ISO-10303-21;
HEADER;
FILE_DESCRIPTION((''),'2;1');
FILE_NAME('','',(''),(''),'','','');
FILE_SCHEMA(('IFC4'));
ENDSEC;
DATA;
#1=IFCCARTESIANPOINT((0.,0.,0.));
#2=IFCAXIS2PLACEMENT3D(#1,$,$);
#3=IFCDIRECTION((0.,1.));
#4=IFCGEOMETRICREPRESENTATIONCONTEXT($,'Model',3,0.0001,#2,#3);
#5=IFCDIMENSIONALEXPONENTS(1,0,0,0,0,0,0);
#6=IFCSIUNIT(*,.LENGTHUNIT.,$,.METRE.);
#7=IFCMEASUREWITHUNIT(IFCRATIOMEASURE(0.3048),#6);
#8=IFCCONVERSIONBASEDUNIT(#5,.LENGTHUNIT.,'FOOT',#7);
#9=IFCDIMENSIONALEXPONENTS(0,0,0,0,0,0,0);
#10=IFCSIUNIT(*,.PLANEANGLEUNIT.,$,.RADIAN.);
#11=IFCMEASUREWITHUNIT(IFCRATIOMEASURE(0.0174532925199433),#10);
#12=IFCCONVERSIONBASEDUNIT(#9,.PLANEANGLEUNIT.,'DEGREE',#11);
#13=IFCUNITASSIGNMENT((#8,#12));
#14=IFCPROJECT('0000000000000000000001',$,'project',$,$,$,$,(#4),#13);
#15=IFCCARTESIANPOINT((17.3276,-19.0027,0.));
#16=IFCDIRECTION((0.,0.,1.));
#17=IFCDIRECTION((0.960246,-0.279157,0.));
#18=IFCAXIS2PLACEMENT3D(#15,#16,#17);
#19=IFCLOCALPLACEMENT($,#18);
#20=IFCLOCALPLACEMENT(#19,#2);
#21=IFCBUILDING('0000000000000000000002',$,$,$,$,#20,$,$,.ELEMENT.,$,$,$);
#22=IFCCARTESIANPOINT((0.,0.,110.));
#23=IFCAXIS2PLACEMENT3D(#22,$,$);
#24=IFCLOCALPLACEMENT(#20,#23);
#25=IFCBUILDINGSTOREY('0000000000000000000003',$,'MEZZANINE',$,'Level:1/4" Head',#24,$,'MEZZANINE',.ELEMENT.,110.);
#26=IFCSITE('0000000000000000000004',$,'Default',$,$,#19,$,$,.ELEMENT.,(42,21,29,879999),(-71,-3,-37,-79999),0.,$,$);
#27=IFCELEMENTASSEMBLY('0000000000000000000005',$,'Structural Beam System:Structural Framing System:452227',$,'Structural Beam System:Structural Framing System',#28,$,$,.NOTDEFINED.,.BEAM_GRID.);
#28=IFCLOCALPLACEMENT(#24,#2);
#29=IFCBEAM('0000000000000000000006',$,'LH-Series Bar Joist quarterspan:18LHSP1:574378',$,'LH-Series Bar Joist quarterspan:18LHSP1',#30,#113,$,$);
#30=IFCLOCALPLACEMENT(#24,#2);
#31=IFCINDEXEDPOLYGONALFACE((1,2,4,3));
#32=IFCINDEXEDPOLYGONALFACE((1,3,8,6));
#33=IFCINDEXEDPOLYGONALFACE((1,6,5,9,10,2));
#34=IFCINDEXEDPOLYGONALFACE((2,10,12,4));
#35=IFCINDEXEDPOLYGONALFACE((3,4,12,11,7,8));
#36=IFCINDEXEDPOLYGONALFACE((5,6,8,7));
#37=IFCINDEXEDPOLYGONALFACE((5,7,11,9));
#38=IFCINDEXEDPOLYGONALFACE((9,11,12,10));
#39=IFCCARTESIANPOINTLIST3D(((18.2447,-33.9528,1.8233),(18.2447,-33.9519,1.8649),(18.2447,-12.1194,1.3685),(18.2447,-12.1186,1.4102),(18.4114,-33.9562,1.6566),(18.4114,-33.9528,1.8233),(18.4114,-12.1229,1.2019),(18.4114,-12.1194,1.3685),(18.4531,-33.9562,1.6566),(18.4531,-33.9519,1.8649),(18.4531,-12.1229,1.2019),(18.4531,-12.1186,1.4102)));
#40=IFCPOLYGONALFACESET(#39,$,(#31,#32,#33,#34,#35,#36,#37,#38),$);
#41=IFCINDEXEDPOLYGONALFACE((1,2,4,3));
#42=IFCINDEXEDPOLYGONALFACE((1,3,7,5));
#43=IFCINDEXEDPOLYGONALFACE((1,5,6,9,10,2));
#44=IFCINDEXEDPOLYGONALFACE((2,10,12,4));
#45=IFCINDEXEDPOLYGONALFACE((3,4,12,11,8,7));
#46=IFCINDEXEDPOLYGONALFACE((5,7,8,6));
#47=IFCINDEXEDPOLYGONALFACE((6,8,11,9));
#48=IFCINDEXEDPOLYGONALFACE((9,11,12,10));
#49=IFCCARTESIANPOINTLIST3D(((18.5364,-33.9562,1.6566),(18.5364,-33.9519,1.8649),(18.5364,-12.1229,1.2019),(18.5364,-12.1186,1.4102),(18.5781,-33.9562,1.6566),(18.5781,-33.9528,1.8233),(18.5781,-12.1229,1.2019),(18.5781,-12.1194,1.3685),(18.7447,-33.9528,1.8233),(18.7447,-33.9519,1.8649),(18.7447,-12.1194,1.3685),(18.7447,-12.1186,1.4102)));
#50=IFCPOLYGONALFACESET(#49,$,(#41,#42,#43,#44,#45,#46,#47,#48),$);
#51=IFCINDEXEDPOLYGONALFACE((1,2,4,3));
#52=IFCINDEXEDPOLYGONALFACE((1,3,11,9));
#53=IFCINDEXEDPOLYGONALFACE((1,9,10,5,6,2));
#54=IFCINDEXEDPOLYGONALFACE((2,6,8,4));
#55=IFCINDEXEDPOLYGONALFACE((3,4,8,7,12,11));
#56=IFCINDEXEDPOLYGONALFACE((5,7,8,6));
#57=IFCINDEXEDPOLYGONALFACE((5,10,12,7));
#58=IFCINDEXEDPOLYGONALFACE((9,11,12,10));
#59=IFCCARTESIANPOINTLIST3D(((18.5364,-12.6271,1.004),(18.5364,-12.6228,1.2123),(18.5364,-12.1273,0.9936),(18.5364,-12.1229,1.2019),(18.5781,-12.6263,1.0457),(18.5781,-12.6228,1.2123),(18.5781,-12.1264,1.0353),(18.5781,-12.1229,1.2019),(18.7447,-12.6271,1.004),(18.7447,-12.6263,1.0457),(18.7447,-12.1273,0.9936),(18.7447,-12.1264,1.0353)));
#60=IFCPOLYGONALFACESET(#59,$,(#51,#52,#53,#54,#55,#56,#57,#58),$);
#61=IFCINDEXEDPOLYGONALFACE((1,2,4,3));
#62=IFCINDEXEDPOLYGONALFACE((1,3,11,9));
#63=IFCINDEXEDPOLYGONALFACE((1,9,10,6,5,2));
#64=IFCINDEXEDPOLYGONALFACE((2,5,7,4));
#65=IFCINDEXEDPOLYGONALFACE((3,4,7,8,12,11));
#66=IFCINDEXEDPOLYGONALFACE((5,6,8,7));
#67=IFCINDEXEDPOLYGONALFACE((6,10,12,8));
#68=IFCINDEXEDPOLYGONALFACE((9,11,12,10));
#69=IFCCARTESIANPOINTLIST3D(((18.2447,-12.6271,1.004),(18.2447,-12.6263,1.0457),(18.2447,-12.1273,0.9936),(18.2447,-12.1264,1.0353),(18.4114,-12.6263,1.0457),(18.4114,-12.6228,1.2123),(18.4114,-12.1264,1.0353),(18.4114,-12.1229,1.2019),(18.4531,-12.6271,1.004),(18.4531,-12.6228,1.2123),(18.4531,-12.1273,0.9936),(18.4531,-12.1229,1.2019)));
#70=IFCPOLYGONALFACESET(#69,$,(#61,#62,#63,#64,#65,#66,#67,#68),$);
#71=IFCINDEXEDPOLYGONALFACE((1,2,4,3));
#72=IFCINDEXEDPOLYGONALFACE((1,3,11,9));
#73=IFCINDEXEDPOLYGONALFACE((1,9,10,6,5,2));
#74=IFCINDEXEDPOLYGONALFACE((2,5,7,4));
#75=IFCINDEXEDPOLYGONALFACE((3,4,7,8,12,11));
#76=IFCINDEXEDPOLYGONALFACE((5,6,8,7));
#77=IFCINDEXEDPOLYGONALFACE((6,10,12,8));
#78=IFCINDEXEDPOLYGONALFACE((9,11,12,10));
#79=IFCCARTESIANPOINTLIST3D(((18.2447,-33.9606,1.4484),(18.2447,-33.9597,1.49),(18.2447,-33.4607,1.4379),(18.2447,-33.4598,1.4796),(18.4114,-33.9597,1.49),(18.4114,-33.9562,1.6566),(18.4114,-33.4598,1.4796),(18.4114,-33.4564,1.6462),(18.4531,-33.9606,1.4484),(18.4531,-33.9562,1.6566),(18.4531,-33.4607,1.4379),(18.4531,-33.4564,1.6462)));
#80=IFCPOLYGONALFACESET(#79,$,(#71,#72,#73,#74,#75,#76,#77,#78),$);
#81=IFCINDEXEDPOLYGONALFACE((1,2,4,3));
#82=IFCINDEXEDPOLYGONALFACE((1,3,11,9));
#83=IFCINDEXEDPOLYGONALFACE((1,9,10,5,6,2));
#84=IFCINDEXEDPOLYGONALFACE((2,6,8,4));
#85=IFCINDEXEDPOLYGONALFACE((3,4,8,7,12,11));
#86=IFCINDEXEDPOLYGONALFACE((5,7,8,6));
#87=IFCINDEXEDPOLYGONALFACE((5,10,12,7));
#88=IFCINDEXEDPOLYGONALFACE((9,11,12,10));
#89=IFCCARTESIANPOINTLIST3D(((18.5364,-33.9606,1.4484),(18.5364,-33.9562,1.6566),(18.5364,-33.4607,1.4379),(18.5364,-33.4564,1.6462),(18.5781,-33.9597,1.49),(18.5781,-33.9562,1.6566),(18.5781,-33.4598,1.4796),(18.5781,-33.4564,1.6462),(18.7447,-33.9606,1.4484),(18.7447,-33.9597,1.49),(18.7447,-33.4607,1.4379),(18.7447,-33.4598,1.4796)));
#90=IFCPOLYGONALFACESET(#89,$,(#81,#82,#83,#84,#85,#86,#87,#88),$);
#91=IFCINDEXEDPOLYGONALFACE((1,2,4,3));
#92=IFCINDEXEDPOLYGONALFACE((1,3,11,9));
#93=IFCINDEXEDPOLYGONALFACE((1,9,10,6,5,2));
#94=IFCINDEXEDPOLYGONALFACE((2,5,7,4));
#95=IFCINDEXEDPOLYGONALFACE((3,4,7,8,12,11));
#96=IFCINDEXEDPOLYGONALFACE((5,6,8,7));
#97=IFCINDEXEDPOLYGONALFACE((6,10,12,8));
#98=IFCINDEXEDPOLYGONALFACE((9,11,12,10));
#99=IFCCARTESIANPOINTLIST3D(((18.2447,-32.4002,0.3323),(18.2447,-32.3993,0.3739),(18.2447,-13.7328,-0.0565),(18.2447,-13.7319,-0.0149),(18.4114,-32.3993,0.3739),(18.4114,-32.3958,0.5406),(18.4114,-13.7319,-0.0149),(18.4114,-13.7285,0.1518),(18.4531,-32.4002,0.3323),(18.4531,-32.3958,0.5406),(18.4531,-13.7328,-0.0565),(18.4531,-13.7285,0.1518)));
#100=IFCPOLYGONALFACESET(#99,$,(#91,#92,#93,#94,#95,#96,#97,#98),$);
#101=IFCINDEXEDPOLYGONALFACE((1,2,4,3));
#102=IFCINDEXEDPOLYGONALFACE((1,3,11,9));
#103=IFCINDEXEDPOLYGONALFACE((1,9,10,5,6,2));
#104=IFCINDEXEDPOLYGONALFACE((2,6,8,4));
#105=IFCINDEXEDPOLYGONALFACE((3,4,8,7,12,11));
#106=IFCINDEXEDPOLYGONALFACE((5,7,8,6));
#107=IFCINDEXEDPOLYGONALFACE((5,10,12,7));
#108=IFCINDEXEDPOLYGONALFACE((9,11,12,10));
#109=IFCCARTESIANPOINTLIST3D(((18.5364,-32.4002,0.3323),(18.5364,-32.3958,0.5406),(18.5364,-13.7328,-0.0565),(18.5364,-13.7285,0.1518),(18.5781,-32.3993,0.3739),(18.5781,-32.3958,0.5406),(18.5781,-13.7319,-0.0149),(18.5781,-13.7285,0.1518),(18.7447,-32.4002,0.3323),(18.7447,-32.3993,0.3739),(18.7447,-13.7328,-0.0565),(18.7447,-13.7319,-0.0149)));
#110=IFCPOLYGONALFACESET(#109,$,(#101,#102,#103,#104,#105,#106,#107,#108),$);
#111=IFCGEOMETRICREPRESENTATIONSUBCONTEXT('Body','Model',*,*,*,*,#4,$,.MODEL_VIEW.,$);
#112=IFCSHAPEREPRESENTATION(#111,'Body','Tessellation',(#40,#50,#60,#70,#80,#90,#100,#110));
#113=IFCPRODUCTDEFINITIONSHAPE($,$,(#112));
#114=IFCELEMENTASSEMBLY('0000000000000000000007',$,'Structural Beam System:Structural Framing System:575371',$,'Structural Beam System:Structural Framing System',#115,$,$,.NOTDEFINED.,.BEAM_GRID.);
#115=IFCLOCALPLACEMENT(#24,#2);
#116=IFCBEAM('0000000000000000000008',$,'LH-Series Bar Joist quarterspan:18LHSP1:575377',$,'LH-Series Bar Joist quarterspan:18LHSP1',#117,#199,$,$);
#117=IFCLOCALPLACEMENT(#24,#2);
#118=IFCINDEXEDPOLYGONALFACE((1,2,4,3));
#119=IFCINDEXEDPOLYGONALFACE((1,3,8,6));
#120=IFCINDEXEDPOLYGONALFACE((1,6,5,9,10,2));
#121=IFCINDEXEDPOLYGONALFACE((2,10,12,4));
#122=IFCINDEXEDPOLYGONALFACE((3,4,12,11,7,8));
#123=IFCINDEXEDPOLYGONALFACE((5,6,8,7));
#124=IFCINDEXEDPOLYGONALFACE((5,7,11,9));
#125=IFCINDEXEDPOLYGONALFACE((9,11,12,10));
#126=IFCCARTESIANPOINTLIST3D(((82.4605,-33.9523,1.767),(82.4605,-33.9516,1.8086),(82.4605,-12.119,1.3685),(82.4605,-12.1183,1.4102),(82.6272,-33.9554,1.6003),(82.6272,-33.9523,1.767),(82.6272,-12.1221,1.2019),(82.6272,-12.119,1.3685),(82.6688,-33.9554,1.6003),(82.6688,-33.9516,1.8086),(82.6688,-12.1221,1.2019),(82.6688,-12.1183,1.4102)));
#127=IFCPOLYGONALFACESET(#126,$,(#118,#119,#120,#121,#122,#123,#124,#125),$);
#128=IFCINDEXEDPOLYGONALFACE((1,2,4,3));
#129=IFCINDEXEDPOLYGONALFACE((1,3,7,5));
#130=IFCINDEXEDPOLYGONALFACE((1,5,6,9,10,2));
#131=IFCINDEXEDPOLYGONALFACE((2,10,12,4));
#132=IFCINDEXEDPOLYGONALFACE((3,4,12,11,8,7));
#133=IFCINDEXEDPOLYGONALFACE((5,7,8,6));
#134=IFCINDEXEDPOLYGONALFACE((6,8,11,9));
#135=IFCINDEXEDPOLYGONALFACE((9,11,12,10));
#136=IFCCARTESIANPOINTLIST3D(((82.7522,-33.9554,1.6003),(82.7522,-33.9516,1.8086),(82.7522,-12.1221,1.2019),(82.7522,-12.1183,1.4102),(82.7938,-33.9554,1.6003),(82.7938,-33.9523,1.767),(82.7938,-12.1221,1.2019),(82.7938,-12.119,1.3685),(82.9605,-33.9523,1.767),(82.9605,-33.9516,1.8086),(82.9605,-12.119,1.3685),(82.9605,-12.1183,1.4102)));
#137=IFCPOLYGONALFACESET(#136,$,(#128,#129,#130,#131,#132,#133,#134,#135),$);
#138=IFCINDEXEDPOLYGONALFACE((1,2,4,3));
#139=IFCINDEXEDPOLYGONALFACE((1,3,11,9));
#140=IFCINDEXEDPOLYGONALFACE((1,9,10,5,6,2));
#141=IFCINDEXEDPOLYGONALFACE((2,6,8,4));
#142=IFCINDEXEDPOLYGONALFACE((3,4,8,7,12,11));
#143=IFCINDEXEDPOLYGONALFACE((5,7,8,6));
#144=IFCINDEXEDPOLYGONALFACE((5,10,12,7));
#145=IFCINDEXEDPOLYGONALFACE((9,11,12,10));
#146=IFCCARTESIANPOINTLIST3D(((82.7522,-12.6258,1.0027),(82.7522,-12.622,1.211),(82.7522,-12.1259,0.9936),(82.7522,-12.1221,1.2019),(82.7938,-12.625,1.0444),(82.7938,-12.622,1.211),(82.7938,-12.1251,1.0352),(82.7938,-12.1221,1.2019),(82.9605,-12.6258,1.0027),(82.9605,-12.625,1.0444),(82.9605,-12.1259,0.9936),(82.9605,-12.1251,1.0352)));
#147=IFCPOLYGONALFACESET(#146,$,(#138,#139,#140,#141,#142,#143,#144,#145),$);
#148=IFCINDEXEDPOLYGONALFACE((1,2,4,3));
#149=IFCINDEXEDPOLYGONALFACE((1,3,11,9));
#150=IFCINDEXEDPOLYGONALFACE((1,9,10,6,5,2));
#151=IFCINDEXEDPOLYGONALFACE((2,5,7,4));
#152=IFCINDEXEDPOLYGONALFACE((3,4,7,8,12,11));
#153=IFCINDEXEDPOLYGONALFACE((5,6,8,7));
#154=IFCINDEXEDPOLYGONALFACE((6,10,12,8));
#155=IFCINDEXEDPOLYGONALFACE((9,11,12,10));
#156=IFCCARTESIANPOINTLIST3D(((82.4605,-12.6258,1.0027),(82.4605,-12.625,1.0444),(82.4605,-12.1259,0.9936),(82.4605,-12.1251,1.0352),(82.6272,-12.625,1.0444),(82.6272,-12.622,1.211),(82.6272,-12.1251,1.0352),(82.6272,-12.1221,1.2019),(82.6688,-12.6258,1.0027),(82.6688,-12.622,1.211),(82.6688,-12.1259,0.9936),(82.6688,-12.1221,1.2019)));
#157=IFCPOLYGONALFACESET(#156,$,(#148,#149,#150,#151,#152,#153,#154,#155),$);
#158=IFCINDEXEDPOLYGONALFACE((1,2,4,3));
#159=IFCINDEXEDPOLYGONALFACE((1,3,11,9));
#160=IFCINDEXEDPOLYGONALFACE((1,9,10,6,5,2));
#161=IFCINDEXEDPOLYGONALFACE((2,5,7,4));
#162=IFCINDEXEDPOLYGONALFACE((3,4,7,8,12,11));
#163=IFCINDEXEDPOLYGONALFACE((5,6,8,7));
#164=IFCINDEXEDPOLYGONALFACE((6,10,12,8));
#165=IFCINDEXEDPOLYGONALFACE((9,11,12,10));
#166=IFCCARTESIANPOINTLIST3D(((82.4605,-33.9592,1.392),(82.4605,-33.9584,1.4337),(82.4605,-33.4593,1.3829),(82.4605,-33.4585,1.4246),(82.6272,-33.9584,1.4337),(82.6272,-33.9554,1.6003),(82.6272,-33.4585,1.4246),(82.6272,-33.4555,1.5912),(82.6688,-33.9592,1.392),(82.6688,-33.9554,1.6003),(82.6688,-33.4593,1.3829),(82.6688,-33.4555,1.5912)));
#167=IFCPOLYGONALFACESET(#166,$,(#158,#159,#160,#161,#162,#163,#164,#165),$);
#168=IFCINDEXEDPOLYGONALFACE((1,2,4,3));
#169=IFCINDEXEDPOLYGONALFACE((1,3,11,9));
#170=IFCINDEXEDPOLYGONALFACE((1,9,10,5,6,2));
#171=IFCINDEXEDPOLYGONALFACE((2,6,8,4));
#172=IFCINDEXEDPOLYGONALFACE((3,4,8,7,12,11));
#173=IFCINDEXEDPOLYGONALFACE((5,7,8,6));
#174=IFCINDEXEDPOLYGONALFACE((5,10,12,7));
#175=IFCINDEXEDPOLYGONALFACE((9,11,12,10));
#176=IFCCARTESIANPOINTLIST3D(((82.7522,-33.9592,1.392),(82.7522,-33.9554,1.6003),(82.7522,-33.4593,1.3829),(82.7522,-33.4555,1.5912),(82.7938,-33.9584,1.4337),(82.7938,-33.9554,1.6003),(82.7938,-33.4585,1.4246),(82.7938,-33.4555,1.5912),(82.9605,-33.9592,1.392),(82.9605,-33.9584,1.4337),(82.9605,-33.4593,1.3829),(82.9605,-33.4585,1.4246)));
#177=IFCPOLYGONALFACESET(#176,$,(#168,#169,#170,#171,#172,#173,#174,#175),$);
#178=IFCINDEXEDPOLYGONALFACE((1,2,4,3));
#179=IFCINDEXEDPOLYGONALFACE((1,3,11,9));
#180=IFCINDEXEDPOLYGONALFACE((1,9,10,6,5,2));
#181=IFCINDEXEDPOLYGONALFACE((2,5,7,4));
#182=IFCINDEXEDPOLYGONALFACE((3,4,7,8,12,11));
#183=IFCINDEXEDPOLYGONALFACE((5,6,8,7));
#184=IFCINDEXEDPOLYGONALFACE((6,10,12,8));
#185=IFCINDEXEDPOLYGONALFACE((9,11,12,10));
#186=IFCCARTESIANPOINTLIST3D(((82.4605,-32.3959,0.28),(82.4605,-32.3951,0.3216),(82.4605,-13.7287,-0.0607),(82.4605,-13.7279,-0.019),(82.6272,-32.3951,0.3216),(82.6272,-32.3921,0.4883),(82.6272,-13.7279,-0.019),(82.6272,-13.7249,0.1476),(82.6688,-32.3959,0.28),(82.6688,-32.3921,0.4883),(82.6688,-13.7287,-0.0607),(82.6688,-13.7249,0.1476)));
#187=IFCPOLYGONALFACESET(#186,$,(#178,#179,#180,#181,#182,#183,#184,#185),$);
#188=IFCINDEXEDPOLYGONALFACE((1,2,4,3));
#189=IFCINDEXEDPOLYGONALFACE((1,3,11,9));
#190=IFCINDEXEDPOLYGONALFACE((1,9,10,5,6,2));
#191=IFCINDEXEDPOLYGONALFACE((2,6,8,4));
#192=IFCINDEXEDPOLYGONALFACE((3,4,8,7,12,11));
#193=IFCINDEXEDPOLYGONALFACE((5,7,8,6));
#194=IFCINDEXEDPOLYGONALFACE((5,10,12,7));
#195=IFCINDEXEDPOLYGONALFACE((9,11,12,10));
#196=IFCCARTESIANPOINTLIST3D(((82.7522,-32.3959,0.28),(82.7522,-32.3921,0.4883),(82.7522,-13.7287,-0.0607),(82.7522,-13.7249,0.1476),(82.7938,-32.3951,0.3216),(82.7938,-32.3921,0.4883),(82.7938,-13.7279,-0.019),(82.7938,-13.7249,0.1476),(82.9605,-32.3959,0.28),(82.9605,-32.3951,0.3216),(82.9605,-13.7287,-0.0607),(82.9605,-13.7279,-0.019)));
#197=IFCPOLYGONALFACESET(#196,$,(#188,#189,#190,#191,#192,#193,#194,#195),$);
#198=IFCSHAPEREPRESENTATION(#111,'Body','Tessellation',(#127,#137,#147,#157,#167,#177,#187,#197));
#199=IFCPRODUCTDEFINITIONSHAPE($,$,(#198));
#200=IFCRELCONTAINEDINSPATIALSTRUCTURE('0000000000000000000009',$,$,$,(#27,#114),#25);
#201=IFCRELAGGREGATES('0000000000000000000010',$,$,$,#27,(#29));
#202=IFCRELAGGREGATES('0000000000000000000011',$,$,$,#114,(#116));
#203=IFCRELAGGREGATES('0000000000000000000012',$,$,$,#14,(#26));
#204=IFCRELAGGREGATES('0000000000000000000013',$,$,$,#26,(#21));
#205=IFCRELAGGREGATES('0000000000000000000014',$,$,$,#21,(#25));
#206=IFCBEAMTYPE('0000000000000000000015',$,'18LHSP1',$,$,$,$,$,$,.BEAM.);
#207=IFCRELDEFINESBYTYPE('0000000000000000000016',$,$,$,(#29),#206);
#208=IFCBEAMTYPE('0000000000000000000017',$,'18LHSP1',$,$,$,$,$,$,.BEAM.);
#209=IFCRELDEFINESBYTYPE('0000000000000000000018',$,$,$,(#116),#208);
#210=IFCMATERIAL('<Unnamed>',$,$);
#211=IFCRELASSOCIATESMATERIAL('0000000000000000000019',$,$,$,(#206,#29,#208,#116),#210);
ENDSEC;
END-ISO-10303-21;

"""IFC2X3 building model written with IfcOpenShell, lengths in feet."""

from ifc_helpers import new_model, entity, si_unit, converted_unit, direction, frame, origin, place, context, subcontext, project, spatial, polyline, outline, extrude, source, transform, mapped, material, type_object, type_shapes, element, aggregate, save


model = new_model("IFC2X3")

# Units and contexts
model_context = context("Model", 3, precision=0.0001, world=origin(), true_north=direction((0.0, 1.0)))
body_context = subcontext(model_context, "Body", "Model", "MODEL_VIEW")
ifc_project = project(units=[converted_unit("LENGTHUNIT", "FOOT", entity("IfcRatioMeasure", 0.3048), si_unit("LENGTHUNIT", "METRE"), dimensions=[1, 0, 0, 0, 0, 0, 0]), converted_unit("PLANEANGLEUNIT", "DEGREE", entity("IfcRatioMeasure", 0.0174532925199433), si_unit("PLANEANGLEUNIT", "RADIAN"), dimensions=[0, 0, 0, 0, 0, 0, 0])], contexts=[model_context])

# Site, building, storey
site_placement = place(None, frame((17.3276, -19.0027, 0.0), z_axis=(0.0, 0.0, 1.0), x_axis=(0.960246, -0.279157, 0.0)))
site = spatial("IfcSite", under=ifc_project, at=site_placement, Name="Default", CompositionType="ELEMENT", RefLatitude=(42, 21, 29, 879999), RefLongitude=(-71, -3, -37, -79999), RefElevation=0.0)
building_placement = place(site_placement, origin())
building = spatial("IfcBuilding", under=site, at=building_placement, CompositionType="ELEMENT")
storey_placement = place(building_placement, frame((0.0, 0.0, 110.0)))
storey = spatial("IfcBuildingStorey", under=building, at=storey_placement, Name="MEZZANINE", ObjectType="Level:1/4\" Head", LongName="MEZZANINE", CompositionType="ELEMENT", Elevation=110.0)

# Element assembly, beam
assembly_1_placement = place(storey_placement, origin())
assembly_1 = element("IfcElementAssembly", 1, at=assembly_1_placement, inside=storey, Name="Structural Beam System:Structural Framing System:452227", ObjectType="Structural Beam System:Structural Framing System", AssemblyPlace="NOTDEFINED", PredefinedType="BEAM_GRID")
ifc_material_1 = material(Name="<Unnamed>")
beam_type_1 = type_object("IfcBeamType", Name="18LHSP1", PredefinedType="BEAM", material=ifc_material_1)
shared_shape_1 = source(origin(), body_context, "Body", "SweptSolid", [
    extrude(outline(polyline([(-0.0833, -0.125), (-0.0417, -0.125), (-0.0417, 0.0417), (0.125, 0.0417), (0.125, 0.0833), (-0.0833, 0.0833), (-0.0833, -0.125)])), frame((-10.919, -0.125, 0.6667), z_axis=(1.0, 0.0, 0.0), x_axis=(0.0, 0.0, -1.0)), (0.0, 0.0, 1.0), 21.8381),
    extrude(outline(polyline([(-0.0833, -0.0833), (0.125, -0.0833), (0.125, -0.0417), (-0.0417, -0.0417), (-0.0417, 0.125), (-0.0833, 0.125), (-0.0833, -0.0833)])), frame((-10.919, 0.125, 0.6667), z_axis=(1.0, 0.0, 0.0), x_axis=(0.0, 0.0, -1.0)), (0.0, 0.0, 1.0), 21.8381),
    extrude(outline(polyline([(-0.125, -0.0833), (0.0833, -0.0833), (0.0833, 0.125), (0.0417, 0.125), (0.0417, -0.0417), (-0.125, -0.0417), (-0.125, -0.0833)])), frame((-10.919, 0.125, 0.4167), z_axis=(1.0, 0.0, 0.0), x_axis=(0.0, 0.0, -1.0)), (0.0, 0.0, 1.0), 0.5),
    extrude(outline(polyline([(0.0417, -0.125), (0.0833, -0.125), (0.0833, 0.0833), (-0.125, 0.0833), (-0.125, 0.0417), (0.0417, 0.0417), (0.0417, -0.125)])), frame((-10.919, -0.125, 0.4167), z_axis=(1.0, 0.0, 0.0), x_axis=(0.0, 0.0, -1.0)), (0.0, 0.0, 1.0), 0.5),
    extrude(outline(polyline([(0.0417, -0.125), (0.0833, -0.125), (0.0833, 0.0833), (-0.125, 0.0833), (-0.125, 0.0417), (0.0417, 0.0417), (0.0417, -0.125)])), frame((10.419, -0.125, 0.4167), z_axis=(1.0, 0.0, 0.0), x_axis=(0.0, 0.0, -1.0)), (0.0, 0.0, 1.0), 0.5),
    extrude(outline(polyline([(-0.125, -0.0833), (0.0833, -0.0833), (0.0833, 0.125), (0.0417, 0.125), (0.0417, -0.0417), (-0.125, -0.0417), (-0.125, -0.0833)])), frame((10.419, 0.125, 0.4167), z_axis=(1.0, 0.0, 0.0), x_axis=(0.0, 0.0, -1.0)), (0.0, 0.0, 1.0), 0.5),
    extrude(outline(polyline([(0.0417, -0.125), (0.0833, -0.125), (0.0833, 0.0833), (-0.125, 0.0833), (-0.125, 0.0417), (0.0417, 0.0417), (0.0417, -0.125)])), frame((-9.3357, -0.125, -0.6667), z_axis=(1.0, 0.0, 0.0), x_axis=(0.0, 0.0, -1.0)), (0.0, 0.0, 1.0), 18.6714),
    extrude(outline(polyline([(-0.125, -0.0833), (0.0833, -0.0833), (0.0833, 0.125), (0.0417, 0.125), (0.0417, -0.0417), (-0.125, -0.0417), (-0.125, -0.0833)])), frame((-9.3357, 0.125, -0.6667), z_axis=(1.0, 0.0, 0.0), x_axis=(0.0, 0.0, -1.0)), (0.0, 0.0, 1.0), 18.6714),
])
type_shapes(beam_type_1, [shared_shape_1])
beam_1_placement = place(assembly_1_placement, frame((18.4947, -23.0509, 0.8877), z_axis=(0.0, 0.020824, 0.999783), x_axis=(0.0, -0.999783, 0.020824)))
beam_1 = element("IfcBeam", 2, at=beam_1_placement, type_object=beam_type_1, material=ifc_material_1, Name="LH-Series Bar Joist quarterspan:18LHSP1:574378", ObjectType="LH-Series Bar Joist quarterspan:18LHSP1", context=body_context, shape_type="MappedRepresentation", body=[
    mapped(shared_shape_1, transform((0.0, 0.0, 0.0), scale=1.0)),
])
aggregate(assembly_1, [beam_1])

# Element assembly, beam
assembly_2_placement = place(storey_placement, origin())
assembly_2 = element("IfcElementAssembly", 3, at=assembly_2_placement, inside=storey, Name="Structural Beam System:Structural Framing System:575371", ObjectType="Structural Beam System:Structural Framing System", AssemblyPlace="NOTDEFINED", PredefinedType="BEAM_GRID")
beam_type_2 = type_object("IfcBeamType", Name="18LHSP1", PredefinedType="BEAM", material=ifc_material_1)
shared_shape_2 = source(origin(), body_context, "Body", "SweptSolid", [
    extrude(outline(polyline([(-0.0833, -0.125), (-0.0417, -0.125), (-0.0417, 0.0417), (0.125, 0.0417), (0.125, 0.0833), (-0.0833, 0.0833), (-0.0833, -0.125)])), frame((-10.9185, -0.125, 0.6667), z_axis=(1.0, 0.0, 0.0), x_axis=(0.0, 0.0, -1.0)), (0.0, 0.0, 1.0), 21.837),
    extrude(outline(polyline([(-0.0833, -0.0833), (0.125, -0.0833), (0.125, -0.0417), (-0.0417, -0.0417), (-0.0417, 0.125), (-0.0833, 0.125), (-0.0833, -0.0833)])), frame((-10.9185, 0.125, 0.6667), z_axis=(1.0, 0.0, 0.0), x_axis=(0.0, 0.0, -1.0)), (0.0, 0.0, 1.0), 21.837),
    extrude(outline(polyline([(-0.125, -0.0833), (0.0833, -0.0833), (0.0833, 0.125), (0.0417, 0.125), (0.0417, -0.0417), (-0.125, -0.0417), (-0.125, -0.0833)])), frame((-10.9185, 0.125, 0.4167), z_axis=(1.0, 0.0, 0.0), x_axis=(0.0, 0.0, -1.0)), (0.0, 0.0, 1.0), 0.5),
    extrude(outline(polyline([(0.0417, -0.125), (0.0833, -0.125), (0.0833, 0.0833), (-0.125, 0.0833), (-0.125, 0.0417), (0.0417, 0.0417), (0.0417, -0.125)])), frame((-10.9185, -0.125, 0.4167), z_axis=(1.0, 0.0, 0.0), x_axis=(0.0, 0.0, -1.0)), (0.0, 0.0, 1.0), 0.5),
    extrude(outline(polyline([(0.0417, -0.125), (0.0833, -0.125), (0.0833, 0.0833), (-0.125, 0.0833), (-0.125, 0.0417), (0.0417, 0.0417), (0.0417, -0.125)])), frame((10.4185, -0.125, 0.4167), z_axis=(1.0, 0.0, 0.0), x_axis=(0.0, 0.0, -1.0)), (0.0, 0.0, 1.0), 0.5),
    extrude(outline(polyline([(-0.125, -0.0833), (0.0833, -0.0833), (0.0833, 0.125), (0.0417, 0.125), (0.0417, -0.0417), (-0.125, -0.0417), (-0.125, -0.0833)])), frame((10.4185, 0.125, 0.4167), z_axis=(1.0, 0.0, 0.0), x_axis=(0.0, 0.0, -1.0)), (0.0, 0.0, 1.0), 0.5),
    extrude(outline(polyline([(0.0417, -0.125), (0.0833, -0.125), (0.0833, 0.0833), (-0.125, 0.0833), (-0.125, 0.0417), (0.0417, 0.0417), (0.0417, -0.125)])), frame((-9.3352, -0.125, -0.6667), z_axis=(1.0, 0.0, 0.0), x_axis=(0.0, 0.0, -1.0)), (0.0, 0.0, 1.0), 18.6703),
    extrude(outline(polyline([(-0.125, -0.0833), (0.0833, -0.0833), (0.0833, 0.125), (0.0417, 0.125), (0.0417, -0.0417), (-0.125, -0.0417), (-0.125, -0.0833)])), frame((-9.3352, 0.125, -0.6667), z_axis=(1.0, 0.0, 0.0), x_axis=(0.0, 0.0, -1.0)), (0.0, 0.0, 1.0), 18.6703),
])
type_shapes(beam_type_2, [shared_shape_2])
beam_2_placement = place(assembly_2_placement, frame((82.7105, -23.0486, 0.8595), z_axis=(0.0, 0.018246, 0.999834), x_axis=(0.0, -0.999834, 0.018246)))
beam_2 = element("IfcBeam", 4, at=beam_2_placement, type_object=beam_type_2, material=ifc_material_1, Name="LH-Series Bar Joist quarterspan:18LHSP1:575377", ObjectType="LH-Series Bar Joist quarterspan:18LHSP1", context=body_context, shape_type="MappedRepresentation", body=[
    mapped(shared_shape_2, transform((0.0, 0.0, 0.0), scale=1.0)),
])
aggregate(assembly_2, [beam_2])

save(model, "model.ifc")
